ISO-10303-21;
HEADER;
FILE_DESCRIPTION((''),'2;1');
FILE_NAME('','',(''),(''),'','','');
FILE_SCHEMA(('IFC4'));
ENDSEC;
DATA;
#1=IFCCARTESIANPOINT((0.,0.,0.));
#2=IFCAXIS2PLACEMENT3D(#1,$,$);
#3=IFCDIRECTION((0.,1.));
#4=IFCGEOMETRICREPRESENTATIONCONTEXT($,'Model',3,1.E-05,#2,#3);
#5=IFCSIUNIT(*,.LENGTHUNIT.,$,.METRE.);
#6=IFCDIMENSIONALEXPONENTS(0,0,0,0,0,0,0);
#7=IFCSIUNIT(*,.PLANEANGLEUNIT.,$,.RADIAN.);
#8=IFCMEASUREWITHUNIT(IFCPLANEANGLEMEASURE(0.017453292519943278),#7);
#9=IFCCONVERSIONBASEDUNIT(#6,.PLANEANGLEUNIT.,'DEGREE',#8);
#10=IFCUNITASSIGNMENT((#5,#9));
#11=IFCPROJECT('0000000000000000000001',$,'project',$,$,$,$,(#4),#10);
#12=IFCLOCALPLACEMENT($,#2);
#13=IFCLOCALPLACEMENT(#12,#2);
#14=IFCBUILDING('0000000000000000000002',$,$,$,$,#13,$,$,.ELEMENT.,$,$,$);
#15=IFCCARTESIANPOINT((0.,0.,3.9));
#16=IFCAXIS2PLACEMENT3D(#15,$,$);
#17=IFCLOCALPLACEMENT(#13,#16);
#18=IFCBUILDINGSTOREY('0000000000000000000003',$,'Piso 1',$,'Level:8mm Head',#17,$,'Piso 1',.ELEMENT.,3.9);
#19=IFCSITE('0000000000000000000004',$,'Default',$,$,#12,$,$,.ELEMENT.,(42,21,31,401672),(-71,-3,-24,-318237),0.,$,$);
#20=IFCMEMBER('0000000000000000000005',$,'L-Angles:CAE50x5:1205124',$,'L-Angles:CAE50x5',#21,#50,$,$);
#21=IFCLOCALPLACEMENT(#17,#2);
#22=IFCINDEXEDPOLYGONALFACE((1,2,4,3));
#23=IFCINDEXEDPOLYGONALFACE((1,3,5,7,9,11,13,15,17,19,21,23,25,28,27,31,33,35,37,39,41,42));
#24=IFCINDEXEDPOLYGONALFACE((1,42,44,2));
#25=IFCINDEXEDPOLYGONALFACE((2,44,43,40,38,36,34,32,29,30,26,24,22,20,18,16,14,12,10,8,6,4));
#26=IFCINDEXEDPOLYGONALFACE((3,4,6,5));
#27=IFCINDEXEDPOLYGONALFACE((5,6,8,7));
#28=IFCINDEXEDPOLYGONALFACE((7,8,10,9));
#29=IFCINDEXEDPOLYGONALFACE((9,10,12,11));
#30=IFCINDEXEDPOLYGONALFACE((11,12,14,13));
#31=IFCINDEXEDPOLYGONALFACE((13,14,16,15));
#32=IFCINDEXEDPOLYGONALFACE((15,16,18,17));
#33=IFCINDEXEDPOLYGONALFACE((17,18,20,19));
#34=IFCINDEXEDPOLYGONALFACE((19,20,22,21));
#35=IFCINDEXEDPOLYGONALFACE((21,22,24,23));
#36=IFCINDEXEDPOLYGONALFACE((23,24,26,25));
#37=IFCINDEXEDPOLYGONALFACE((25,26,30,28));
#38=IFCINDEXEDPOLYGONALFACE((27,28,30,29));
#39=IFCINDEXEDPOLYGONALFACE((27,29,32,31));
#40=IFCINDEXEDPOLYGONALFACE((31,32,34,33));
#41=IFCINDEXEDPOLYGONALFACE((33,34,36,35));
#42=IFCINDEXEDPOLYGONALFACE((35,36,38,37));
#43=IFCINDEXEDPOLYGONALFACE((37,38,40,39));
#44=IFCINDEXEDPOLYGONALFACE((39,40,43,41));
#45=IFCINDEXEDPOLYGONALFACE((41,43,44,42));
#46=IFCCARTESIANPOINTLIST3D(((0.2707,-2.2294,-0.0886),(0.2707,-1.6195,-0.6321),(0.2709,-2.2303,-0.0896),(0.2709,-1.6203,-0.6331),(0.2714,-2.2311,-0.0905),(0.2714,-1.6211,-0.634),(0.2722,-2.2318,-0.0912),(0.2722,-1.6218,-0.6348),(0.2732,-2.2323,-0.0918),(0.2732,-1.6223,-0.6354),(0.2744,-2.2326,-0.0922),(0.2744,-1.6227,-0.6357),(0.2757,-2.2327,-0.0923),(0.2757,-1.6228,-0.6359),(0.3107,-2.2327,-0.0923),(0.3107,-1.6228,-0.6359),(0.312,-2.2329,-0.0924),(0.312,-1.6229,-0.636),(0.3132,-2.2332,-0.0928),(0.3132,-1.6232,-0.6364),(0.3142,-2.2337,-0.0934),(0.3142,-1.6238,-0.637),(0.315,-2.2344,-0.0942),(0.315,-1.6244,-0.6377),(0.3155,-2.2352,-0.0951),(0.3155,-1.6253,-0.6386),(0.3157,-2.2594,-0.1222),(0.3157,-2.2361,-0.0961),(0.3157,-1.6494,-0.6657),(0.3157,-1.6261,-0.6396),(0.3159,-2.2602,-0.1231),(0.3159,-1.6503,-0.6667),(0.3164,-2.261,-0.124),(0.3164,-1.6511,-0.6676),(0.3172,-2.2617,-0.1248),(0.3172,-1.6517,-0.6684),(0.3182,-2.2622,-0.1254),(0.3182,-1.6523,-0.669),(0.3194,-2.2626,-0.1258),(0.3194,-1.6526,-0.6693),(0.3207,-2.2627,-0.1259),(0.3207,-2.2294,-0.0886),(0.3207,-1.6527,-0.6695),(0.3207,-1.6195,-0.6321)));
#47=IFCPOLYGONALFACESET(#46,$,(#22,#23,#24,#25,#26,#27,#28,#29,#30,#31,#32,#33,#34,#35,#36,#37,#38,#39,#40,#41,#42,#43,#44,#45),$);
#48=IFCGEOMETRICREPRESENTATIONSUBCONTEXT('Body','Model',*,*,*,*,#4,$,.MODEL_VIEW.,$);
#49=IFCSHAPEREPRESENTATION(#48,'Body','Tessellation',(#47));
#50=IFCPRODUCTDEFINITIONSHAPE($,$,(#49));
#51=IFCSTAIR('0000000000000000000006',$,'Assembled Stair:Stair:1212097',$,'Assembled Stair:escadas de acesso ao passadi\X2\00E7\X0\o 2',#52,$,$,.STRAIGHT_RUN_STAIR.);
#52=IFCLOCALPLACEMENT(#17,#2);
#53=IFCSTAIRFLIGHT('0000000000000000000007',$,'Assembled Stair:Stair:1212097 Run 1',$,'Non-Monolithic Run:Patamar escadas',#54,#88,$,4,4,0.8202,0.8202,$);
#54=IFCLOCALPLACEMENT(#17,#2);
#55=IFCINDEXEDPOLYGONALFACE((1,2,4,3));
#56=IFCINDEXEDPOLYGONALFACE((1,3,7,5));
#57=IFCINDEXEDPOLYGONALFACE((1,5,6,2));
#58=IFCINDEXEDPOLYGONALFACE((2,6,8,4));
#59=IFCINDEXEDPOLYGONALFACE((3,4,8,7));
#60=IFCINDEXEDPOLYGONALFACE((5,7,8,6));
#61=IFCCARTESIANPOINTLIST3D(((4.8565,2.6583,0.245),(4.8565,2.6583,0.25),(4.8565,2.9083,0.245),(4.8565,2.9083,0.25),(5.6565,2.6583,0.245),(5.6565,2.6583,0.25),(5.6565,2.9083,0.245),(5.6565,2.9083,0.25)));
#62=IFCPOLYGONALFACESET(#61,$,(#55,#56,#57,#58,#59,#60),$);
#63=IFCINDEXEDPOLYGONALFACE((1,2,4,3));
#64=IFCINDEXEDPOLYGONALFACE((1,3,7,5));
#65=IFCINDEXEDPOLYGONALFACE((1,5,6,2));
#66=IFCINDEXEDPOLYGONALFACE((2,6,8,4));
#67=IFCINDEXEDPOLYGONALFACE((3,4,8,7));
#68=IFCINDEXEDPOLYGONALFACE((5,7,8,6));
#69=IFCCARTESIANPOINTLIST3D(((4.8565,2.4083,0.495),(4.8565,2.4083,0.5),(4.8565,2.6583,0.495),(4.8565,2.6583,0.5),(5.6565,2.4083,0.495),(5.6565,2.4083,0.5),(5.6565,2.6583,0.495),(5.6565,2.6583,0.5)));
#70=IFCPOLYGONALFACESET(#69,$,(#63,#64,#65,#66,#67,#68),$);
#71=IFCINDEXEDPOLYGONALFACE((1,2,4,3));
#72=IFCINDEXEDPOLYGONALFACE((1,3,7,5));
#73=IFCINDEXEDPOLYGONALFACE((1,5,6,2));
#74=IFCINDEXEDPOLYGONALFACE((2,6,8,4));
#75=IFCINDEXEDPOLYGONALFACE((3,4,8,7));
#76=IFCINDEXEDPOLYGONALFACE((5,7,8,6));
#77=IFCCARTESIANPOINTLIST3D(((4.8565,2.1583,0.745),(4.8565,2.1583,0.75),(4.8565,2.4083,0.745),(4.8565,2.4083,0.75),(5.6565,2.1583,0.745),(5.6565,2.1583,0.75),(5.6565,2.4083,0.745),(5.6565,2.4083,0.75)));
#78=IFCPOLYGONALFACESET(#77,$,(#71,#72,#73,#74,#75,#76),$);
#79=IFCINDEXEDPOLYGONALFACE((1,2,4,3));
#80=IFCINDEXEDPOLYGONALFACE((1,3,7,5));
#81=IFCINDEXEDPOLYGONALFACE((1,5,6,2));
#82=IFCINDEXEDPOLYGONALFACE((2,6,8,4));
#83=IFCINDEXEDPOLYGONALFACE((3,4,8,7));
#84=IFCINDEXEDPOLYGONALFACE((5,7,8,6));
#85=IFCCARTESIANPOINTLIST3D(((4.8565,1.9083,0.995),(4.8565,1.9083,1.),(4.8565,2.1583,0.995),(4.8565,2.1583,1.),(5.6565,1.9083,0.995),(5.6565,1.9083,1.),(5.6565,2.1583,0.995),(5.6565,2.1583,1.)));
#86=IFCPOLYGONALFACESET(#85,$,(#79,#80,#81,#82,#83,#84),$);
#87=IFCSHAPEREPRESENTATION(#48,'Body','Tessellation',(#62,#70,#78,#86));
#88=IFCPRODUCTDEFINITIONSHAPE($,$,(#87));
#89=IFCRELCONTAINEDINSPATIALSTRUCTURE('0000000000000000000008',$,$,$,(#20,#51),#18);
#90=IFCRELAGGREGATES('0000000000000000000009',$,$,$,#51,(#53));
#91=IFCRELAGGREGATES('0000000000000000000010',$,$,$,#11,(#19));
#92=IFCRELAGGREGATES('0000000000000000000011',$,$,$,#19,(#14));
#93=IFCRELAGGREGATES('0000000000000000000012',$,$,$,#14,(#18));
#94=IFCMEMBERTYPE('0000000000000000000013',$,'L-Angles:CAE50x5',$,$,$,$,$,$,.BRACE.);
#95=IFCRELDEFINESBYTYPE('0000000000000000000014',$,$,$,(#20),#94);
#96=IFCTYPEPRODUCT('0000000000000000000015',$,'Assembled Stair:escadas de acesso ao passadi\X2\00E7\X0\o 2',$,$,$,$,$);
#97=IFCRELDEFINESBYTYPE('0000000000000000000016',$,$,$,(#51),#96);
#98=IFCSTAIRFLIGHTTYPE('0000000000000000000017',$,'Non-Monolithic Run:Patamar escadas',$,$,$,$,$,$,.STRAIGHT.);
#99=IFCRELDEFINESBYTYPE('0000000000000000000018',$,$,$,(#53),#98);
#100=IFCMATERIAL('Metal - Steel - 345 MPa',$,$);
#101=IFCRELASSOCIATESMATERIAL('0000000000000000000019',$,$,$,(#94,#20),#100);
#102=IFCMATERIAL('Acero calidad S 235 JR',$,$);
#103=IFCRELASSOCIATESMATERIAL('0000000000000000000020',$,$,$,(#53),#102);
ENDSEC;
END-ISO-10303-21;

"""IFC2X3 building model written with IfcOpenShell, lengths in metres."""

from ifc_helpers import new_model, entity, si_unit, converted_unit, direction, frame, frame_2d, origin, place, context, subcontext, project, spatial, polyline, circle_curve, parameter, trimmed, segment, composite_curve, rectangle, outline, extrude, source, transform, mapped, material, type_object, type_shapes, element, aggregate, save


model = new_model("IFC2X3")

# Units and contexts
model_context = context("Model", 3, precision=1e-05, world=origin(), true_north=direction((0.0, 1.0)))
body_context = subcontext(model_context, "Body", "Model", "MODEL_VIEW")
ifc_project = project(units=[si_unit("LENGTHUNIT", "METRE"), converted_unit("PLANEANGLEUNIT", "DEGREE", entity("IfcPlaneAngleMeasure", 0.017453292519943278), si_unit("PLANEANGLEUNIT", "RADIAN"), dimensions=[0, 0, 0, 0, 0, 0, 0])], contexts=[model_context])

# Site, building, storey
site_placement = place(None, origin())
site = spatial("IfcSite", under=ifc_project, at=site_placement, Name="Default", CompositionType="ELEMENT", RefLatitude=(42, 21, 31, 401672), RefLongitude=(-71, -3, -24, -318237), RefElevation=0.0)
building_placement = place(site_placement, origin())
building = spatial("IfcBuilding", under=site, at=building_placement, CompositionType="ELEMENT")
storey_placement = place(building_placement, frame((0.0, 0.0, 3.9)))
storey = spatial("IfcBuildingStorey", under=building, at=storey_placement, Name="Piso 1", ObjectType="Level:8mm Head", LongName="Piso 1", CompositionType="ELEMENT", Elevation=3.9)

# Shared definitions
ifc_material_1 = material(Name="Metal - Steel - 345 MPa")

# Member
member_type_1 = type_object("IfcMemberType", Name="L-Angles:CAE50x5", PredefinedType="BRACE", material=ifc_material_1)
shared_shape_1 = source(origin(), body_context, "Body", "SweptSolid", [
    extrude(outline(composite_curve([segment(polyline([(-0.0164, -0.0164), (0.0336, -0.0164)]), True, "CONTINUOUS"), segment(trimmed(circle_curve(frame_2d((0.0286, -0.0164), x_axis=(1.0, 0.0)), 0.005), [parameter(0.0)], [parameter(90.0)], True, "PARAMETER"), True, "CONTINUOUS"), segment(polyline([(0.0286, -0.0114), (-0.0064, -0.0114)]), True, "CONTINUOUS"), segment(trimmed(circle_curve(frame_2d((-0.0064, -0.0064), x_axis=(1.0, 0.0)), 0.005), [parameter(180.0)], [parameter(270.0)], True, "PARAMETER"), False, "CONTINUOUS"), segment(polyline([(-0.0114, -0.0064), (-0.0114, 0.0286)]), True, "CONTINUOUS"), segment(trimmed(circle_curve(frame_2d((-0.0164, 0.0286), x_axis=(1.0, 0.0)), 0.005), [parameter(0.0)], [parameter(90.0)], True, "PARAMETER"), True, "CONTINUOUS"), segment(polyline([(-0.0164, 0.0336), (-0.0164, -0.0164)]), True, "CONTINUOUS")], self_intersect=False)), frame((-0.398, -0.0024, -0.0024), z_axis=(1.0, 0.0, 0.0), x_axis=(0.0, -1.0, 0.0)), (0.0, 0.0, 1.0), 0.817),
])
type_shapes(member_type_1, [shared_shape_1])
member_1_placement = place(storey_placement, frame((0.3067, -1.9259, -0.3778), z_axis=(0.0, 0.665289, 0.746586), x_axis=(0.0, -0.746586, 0.665289)))
element("IfcMember", 1, at=member_1_placement, inside=storey, type_object=member_type_1, material=ifc_material_1, Name="L-Angles:CAE50x5:1205124", ObjectType="L-Angles:CAE50x5", context=body_context, shape_type="MappedRepresentation", body=[
    mapped(shared_shape_1, transform((0.0, 0.0, 0.0), scale=1.0)),
])

# Stair, stair flight
type_product = type_object("IfcTypeProduct", Name="Assembled Stair:escadas de acesso ao passadiço 2")
stair_placement = place(storey_placement, origin())
stair = element("IfcStair", 2, at=stair_placement, inside=storey, type_object=type_product, Name="Assembled Stair:Stair:1212097", ObjectType="Assembled Stair:escadas de acesso ao passadiço 2", ShapeType="STRAIGHT_RUN_STAIR")
ifc_material_2 = material(Name="Acero calidad S 235 JR")
stair_flight_type = type_object("IfcStairFlightType", Name="Non-Monolithic Run:Patamar escadas", PredefinedType="STRAIGHT")
stair_flight_placement = place(stair_placement, origin())
stair_flight = element("IfcStairFlight", 3, at=stair_flight_placement, type_object=stair_flight_type, material=ifc_material_2, Name="Assembled Stair:Stair:1212097 Run 1", ObjectType="Non-Monolithic Run:Patamar escadas", NumberOfRiser=4, NumberOfTreads=4, RiserHeight=0.8202, TreadLength=0.8202, context=body_context, shape_type="SweptSolid", body=[
    extrude(rectangle(XDim=0.25, YDim=0.8, at=frame_2d((0.0, 0.0), x_axis=(1.0, 0.0))), frame((5.2565, 2.7833, 0.245), z_axis=(0.0, 0.0, 1.0), x_axis=(0.0, 1.0, 0.0)), (0.0, 0.0, 1.0), 0.005),
    extrude(rectangle(XDim=0.25, YDim=0.8, at=frame_2d((0.0, 0.0), x_axis=(1.0, 0.0))), frame((5.2565, 2.5333, 0.495), z_axis=(0.0, 0.0, 1.0), x_axis=(0.0, 1.0, 0.0)), (0.0, 0.0, 1.0), 0.005),
    extrude(rectangle(XDim=0.25, YDim=0.8, at=frame_2d((0.0, 0.0), x_axis=(1.0, 0.0))), frame((5.2565, 2.2833, 0.745), z_axis=(0.0, 0.0, 1.0), x_axis=(0.0, 1.0, 0.0)), (0.0, 0.0, 1.0), 0.005),
    extrude(rectangle(XDim=0.25, YDim=0.8, at=frame_2d((0.0, 0.0), x_axis=(1.0, 0.0))), frame((5.2565, 2.0333, 0.995), z_axis=(0.0, 0.0, 1.0), x_axis=(0.0, 1.0, 0.0)), (0.0, 0.0, 1.0), 0.005),
])
aggregate(stair, [stair_flight])

save(model, "model.ifc")
